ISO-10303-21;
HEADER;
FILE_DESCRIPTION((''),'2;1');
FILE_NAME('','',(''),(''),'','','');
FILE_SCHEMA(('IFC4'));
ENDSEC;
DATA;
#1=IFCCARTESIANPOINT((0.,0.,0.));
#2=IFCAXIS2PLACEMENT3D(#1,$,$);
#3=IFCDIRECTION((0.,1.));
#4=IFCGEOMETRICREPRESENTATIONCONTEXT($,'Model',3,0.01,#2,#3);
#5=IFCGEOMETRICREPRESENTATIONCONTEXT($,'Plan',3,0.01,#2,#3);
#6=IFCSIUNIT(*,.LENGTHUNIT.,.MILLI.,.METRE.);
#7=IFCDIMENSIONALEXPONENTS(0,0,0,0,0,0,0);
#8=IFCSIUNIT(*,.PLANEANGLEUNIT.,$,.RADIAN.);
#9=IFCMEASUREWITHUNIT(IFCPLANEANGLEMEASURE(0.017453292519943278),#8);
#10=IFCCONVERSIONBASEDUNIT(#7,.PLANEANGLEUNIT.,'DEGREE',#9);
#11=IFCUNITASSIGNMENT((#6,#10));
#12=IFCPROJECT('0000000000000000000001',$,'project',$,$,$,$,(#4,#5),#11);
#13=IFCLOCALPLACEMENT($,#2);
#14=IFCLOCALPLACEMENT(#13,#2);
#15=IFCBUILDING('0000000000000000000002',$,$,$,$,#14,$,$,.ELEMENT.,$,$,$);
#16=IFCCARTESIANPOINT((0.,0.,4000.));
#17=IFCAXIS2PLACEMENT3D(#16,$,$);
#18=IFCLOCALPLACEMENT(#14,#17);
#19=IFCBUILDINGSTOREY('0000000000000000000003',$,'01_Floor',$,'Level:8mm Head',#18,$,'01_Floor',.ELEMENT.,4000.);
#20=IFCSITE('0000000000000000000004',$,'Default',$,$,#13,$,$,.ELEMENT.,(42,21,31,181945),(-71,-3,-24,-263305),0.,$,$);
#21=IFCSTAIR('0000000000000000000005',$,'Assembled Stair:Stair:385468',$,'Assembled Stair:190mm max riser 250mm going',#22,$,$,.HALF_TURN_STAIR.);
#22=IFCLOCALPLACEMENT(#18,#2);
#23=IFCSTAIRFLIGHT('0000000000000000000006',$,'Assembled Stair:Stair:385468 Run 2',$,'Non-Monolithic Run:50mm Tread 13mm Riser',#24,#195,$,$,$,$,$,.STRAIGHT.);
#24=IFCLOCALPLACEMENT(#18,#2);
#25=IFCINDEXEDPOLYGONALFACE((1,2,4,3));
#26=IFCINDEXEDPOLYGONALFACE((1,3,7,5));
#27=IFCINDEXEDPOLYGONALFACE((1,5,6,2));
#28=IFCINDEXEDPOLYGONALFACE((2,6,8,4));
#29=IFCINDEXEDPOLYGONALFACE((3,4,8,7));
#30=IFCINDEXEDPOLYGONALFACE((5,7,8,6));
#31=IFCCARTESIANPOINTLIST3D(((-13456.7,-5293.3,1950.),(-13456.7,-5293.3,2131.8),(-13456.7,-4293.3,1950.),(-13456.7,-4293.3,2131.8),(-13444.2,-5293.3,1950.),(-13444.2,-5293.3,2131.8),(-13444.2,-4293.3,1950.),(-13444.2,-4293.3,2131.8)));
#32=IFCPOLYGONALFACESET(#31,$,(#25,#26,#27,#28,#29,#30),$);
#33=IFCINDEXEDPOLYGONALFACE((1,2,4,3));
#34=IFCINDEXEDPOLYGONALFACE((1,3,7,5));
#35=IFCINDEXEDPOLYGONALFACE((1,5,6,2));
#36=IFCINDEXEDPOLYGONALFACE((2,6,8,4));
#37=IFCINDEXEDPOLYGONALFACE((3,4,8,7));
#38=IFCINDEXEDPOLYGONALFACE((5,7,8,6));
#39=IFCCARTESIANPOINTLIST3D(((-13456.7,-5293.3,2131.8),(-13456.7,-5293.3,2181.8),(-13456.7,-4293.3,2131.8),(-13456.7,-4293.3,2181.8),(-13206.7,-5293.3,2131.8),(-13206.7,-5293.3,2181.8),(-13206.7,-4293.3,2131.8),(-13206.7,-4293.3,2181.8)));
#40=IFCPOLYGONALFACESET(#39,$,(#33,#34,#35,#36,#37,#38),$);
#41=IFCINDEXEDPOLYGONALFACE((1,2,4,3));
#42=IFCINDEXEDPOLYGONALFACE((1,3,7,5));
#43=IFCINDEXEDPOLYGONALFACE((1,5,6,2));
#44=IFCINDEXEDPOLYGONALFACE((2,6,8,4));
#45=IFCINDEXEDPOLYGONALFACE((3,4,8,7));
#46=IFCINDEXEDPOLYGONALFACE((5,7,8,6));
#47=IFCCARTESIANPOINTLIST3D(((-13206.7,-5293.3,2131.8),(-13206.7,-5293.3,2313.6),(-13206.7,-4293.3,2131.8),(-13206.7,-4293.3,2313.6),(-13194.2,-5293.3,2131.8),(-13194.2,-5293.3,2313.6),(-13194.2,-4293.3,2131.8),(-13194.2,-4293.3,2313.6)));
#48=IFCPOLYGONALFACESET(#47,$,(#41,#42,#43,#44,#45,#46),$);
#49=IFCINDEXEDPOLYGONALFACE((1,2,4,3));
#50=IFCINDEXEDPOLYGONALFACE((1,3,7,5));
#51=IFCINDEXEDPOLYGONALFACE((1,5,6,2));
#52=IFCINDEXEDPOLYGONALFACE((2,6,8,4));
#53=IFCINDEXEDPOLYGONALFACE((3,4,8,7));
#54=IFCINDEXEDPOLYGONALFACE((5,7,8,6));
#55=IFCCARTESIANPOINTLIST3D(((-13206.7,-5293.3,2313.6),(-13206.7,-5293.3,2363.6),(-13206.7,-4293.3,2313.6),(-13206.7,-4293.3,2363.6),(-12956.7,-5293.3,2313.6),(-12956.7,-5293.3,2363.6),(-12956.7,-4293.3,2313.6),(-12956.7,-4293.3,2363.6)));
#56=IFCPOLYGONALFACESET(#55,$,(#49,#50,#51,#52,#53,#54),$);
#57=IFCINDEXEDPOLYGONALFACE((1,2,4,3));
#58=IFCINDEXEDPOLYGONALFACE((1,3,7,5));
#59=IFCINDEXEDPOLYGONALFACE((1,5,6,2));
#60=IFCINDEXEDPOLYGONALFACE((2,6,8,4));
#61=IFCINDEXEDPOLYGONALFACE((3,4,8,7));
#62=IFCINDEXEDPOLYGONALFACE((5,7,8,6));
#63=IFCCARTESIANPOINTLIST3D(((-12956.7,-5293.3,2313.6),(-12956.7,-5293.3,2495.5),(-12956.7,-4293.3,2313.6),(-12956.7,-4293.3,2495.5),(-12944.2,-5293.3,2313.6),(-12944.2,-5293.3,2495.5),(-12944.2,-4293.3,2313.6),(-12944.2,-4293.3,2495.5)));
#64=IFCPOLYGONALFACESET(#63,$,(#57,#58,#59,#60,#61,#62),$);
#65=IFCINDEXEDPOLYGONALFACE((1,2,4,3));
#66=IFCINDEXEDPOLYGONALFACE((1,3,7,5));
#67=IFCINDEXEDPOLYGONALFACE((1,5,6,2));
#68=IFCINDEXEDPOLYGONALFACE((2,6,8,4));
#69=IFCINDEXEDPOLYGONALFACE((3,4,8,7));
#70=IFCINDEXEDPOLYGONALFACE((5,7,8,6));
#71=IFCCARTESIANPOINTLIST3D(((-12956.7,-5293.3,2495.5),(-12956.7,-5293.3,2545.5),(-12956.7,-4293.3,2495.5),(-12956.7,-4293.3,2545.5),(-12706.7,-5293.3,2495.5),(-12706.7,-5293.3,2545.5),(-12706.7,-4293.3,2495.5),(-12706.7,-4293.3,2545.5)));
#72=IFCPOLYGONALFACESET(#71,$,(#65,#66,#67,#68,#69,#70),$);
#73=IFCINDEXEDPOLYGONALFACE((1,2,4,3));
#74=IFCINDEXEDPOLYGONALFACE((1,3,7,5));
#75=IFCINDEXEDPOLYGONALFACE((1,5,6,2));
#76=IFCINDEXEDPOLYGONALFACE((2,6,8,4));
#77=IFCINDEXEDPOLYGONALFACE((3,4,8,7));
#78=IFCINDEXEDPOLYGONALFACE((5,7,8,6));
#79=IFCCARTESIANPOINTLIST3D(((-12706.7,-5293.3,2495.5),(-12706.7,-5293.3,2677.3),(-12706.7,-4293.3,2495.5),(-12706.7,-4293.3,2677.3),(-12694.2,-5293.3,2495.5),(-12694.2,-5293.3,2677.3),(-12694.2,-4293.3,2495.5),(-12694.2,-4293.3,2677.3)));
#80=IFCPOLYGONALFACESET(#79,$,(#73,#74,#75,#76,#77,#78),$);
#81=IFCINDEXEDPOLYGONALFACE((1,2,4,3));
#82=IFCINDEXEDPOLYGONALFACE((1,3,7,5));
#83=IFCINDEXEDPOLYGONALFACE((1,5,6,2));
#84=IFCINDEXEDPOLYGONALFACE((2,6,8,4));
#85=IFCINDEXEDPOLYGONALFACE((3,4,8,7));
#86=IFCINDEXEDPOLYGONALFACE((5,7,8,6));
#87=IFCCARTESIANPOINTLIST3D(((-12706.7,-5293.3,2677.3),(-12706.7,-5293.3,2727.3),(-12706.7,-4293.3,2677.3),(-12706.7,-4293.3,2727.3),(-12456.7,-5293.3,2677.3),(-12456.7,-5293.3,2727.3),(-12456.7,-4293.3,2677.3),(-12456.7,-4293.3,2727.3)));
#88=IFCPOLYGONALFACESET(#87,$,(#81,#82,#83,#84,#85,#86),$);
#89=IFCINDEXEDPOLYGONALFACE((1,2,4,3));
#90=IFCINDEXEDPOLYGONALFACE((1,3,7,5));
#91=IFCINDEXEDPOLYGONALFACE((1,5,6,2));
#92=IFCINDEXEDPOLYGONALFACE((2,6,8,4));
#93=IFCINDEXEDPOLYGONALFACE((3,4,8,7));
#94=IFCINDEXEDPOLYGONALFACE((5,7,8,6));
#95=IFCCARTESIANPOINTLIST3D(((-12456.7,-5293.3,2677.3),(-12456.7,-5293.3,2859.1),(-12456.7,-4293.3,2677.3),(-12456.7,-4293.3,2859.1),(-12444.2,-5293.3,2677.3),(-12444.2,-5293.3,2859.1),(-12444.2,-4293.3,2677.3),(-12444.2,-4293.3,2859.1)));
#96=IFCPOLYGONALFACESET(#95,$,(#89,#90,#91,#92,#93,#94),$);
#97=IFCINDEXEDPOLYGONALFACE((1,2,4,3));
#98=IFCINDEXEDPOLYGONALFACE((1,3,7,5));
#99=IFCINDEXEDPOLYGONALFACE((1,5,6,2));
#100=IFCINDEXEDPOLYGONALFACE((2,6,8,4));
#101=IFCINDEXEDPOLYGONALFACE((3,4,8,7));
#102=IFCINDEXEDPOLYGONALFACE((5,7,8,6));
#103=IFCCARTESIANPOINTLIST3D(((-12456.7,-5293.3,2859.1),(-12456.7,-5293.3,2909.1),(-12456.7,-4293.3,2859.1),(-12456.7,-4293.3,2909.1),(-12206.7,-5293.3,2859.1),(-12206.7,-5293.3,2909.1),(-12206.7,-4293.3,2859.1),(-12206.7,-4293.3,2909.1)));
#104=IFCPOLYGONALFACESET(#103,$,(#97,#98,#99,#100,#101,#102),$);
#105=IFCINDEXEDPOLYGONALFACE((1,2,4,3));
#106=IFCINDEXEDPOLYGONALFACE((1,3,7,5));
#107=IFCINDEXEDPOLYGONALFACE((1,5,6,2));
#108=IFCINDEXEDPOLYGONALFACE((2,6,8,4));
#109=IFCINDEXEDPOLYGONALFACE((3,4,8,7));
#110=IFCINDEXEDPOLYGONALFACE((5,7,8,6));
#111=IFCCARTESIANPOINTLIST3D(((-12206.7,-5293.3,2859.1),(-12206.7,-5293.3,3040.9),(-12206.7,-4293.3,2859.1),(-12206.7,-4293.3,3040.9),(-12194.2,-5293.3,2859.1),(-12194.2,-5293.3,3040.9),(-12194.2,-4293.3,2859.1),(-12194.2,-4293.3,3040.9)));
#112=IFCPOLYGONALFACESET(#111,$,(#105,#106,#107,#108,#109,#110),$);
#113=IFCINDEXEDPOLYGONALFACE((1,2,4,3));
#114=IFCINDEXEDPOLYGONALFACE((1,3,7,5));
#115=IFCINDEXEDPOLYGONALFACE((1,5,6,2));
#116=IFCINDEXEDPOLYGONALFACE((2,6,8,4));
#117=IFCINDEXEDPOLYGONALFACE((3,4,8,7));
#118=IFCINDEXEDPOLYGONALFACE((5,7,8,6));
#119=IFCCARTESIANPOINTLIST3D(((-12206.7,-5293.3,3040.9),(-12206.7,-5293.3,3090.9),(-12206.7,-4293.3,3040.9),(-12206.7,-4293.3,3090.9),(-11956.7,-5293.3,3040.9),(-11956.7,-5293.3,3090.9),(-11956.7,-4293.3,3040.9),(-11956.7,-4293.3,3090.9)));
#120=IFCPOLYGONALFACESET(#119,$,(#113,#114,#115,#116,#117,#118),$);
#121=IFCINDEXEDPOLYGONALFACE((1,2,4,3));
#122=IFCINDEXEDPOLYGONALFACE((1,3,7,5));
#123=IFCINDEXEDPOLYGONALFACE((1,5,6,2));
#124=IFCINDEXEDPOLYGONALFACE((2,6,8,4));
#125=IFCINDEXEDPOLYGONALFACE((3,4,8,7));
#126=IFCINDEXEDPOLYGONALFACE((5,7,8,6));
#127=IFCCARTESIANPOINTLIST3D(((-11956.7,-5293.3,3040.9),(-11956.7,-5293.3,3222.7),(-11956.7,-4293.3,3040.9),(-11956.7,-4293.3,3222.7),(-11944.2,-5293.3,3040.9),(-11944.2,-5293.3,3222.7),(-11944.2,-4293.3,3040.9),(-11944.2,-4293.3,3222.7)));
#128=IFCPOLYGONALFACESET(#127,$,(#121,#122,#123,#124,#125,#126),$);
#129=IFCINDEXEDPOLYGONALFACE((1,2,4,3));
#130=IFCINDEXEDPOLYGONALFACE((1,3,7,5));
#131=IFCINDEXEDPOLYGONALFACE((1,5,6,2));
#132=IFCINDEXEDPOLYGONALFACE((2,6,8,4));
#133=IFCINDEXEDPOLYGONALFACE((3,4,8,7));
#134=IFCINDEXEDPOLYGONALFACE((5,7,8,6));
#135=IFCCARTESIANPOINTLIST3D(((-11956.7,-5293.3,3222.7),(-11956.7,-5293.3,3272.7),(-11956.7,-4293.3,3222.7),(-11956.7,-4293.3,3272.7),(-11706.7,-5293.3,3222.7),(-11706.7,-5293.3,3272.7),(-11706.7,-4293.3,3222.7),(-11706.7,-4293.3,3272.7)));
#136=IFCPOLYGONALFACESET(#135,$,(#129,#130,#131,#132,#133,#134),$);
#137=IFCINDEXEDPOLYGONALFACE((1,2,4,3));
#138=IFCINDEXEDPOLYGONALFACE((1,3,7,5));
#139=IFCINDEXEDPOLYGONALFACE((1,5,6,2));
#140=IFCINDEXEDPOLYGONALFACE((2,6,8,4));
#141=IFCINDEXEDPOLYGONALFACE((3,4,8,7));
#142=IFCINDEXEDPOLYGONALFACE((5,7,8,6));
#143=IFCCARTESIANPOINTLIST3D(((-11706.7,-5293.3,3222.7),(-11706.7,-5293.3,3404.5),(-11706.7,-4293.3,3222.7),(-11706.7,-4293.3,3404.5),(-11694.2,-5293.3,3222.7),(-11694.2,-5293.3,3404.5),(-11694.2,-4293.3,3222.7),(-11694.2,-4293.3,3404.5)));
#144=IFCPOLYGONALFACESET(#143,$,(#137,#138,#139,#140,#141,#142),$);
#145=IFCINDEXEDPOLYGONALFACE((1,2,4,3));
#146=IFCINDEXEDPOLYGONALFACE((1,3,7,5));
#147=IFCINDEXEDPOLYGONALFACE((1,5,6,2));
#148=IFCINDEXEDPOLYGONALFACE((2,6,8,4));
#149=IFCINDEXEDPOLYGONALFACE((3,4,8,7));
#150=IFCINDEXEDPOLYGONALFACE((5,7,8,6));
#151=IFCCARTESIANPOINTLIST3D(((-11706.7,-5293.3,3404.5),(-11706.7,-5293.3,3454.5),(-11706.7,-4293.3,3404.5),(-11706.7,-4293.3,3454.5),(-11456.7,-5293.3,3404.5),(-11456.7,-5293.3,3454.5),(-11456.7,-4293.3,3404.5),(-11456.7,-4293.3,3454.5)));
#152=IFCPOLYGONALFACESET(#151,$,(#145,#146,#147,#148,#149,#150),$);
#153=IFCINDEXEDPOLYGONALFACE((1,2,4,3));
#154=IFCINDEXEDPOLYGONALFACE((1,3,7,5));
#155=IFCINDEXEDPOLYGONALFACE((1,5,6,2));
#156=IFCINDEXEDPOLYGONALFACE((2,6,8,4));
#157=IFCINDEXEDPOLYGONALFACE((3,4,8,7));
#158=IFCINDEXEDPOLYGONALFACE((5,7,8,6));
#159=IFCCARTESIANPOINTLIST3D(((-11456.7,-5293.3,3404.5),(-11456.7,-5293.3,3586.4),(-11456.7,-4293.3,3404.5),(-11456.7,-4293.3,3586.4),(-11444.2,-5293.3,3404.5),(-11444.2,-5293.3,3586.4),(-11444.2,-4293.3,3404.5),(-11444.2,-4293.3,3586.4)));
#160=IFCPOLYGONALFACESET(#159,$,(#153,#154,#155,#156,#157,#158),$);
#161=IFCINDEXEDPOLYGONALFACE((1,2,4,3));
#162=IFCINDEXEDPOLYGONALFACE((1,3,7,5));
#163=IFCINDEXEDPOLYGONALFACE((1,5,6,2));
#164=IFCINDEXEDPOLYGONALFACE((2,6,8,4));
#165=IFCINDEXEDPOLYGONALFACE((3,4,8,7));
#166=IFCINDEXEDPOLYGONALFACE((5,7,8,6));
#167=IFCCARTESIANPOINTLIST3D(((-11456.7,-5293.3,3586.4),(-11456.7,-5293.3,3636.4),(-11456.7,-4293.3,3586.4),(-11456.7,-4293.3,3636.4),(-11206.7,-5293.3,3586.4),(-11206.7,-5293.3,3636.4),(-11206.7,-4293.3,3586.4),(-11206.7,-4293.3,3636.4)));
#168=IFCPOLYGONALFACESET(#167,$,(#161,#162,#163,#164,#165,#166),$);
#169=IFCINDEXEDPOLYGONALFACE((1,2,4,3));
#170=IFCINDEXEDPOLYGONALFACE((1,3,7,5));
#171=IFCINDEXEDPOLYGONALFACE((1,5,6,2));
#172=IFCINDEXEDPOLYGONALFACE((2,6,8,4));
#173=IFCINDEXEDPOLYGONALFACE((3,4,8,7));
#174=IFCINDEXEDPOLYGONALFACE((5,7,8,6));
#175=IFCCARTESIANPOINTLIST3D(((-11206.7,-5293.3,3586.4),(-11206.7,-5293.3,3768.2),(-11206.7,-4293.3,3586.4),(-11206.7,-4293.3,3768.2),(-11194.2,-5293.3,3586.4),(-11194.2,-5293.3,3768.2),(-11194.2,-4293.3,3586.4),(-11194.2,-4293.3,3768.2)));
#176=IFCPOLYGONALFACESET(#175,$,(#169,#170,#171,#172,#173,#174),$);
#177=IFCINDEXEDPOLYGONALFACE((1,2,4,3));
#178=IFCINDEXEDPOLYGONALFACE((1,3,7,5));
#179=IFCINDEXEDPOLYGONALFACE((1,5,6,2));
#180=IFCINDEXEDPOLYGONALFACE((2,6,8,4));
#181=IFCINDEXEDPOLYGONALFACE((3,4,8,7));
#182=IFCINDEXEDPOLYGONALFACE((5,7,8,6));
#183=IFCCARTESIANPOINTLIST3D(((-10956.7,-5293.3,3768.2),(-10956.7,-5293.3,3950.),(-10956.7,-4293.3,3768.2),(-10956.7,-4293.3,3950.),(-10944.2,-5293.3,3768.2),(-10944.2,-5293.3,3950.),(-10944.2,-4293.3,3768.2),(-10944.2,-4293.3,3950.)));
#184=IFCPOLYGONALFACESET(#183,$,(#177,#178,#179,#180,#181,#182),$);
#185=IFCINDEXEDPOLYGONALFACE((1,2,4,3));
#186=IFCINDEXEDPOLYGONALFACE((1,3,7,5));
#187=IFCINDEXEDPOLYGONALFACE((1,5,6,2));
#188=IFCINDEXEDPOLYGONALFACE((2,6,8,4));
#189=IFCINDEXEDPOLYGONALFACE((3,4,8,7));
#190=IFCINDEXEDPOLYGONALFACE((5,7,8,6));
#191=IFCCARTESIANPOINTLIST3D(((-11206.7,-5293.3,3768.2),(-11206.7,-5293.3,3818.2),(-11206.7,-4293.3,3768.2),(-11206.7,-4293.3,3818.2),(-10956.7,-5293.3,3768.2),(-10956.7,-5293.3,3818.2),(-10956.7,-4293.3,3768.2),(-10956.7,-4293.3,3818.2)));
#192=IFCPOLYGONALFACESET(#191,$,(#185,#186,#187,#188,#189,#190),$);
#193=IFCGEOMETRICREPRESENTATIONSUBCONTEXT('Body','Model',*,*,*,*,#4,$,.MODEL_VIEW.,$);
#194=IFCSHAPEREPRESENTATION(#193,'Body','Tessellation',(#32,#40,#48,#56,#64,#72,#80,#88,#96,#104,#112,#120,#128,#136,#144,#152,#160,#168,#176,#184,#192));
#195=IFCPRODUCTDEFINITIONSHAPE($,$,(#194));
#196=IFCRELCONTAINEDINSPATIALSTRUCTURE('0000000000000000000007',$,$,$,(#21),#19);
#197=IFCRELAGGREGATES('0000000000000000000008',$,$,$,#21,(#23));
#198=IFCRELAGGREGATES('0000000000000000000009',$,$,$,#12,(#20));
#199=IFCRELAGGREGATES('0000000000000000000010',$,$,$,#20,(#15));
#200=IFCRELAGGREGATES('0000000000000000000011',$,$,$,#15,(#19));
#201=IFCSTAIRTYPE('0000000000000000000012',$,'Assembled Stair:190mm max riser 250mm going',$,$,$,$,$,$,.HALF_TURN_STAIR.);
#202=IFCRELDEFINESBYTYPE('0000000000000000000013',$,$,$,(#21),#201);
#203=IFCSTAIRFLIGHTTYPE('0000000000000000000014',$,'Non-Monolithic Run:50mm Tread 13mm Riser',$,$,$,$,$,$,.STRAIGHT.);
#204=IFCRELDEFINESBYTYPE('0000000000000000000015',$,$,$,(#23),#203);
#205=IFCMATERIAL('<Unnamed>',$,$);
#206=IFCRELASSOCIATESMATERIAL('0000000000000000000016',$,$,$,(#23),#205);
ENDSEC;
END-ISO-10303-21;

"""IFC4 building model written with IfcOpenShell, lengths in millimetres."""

from ifc_helpers import new_model, entity, si_unit, converted_unit, direction, frame, origin, place, context, subcontext, project, spatial, indexed_curve, outline, extrude, material, type_object, element, aggregate, save


model = new_model("IFC4")

# Units and contexts
model_context = context("Model", 3, precision=0.01, world=origin(), true_north=direction((0.0, 1.0)))
plan_context = context("Plan", 3, precision=0.01, world=origin(), true_north=direction((0.0, 1.0)))
body_context = subcontext(model_context, "Body", "Model", "MODEL_VIEW")
ifc_project = project(units=[si_unit("LENGTHUNIT", "METRE", prefix="MILLI"), converted_unit("PLANEANGLEUNIT", "DEGREE", entity("IfcPlaneAngleMeasure", 0.017453292519943278), si_unit("PLANEANGLEUNIT", "RADIAN"), dimensions=[0, 0, 0, 0, 0, 0, 0])], contexts=[model_context, plan_context])

# Site, building, storey
site_placement = place(None, origin())
site = spatial("IfcSite", under=ifc_project, at=site_placement, Name="Default", CompositionType="ELEMENT", RefLatitude=(42, 21, 31, 181945), RefLongitude=(-71, -3, -24, -263305), RefElevation=0.0)
building_placement = place(site_placement, origin())
building = spatial("IfcBuilding", under=site, at=building_placement, CompositionType="ELEMENT")
storey_placement = place(building_placement, frame((0.0, 0.0, 4000.0)))
storey = spatial("IfcBuildingStorey", under=building, at=storey_placement, Name="01_Floor", ObjectType="Level:8mm Head", LongName="01_Floor", CompositionType="ELEMENT", Elevation=4000.0)

# Stair
stair_type = type_object("IfcStairType", Name="Assembled Stair:190mm max riser 250mm going", PredefinedType="HALF_TURN_STAIR")
stair_placement = place(storey_placement, origin())
stair = element("IfcStair", 1, at=stair_placement, inside=storey, type_object=stair_type, Name="Assembled Stair:Stair:385468", ObjectType="Assembled Stair:190mm max riser 250mm going", PredefinedType="HALF_TURN_STAIR")
ifc_material_1 = material(Name="<Unnamed>")

# Stair flight
stair_flight_type = type_object("IfcStairFlightType", Name="Non-Monolithic Run:50mm Tread 13mm Riser", PredefinedType="STRAIGHT")
stair_flight_1_placement = place(stair_placement, origin())
stair_flight_1 = element("IfcStairFlight", 2, at=stair_flight_1_placement, type_object=stair_flight_type, material=ifc_material_1, Name="Assembled Stair:Stair:385468 Run 2", ObjectType="Non-Monolithic Run:50mm Tread 13mm Riser", PredefinedType="STRAIGHT", context=body_context, shape_type="SweptSolid", body=[
    extrude(outline(indexed_curve([(-500.0, -6.3), (500.0, -6.3), (500.0, 6.2), (-500.0, 6.2), (-500.0, -6.3)], self_intersect=False)), frame((-13450.4, -4793.3, 1950.0), z_axis=(0.0, 0.0, 1.0), x_axis=(0.0, 1.0, 0.0)), (0.0, 0.0, 1.0), 181.8),
    extrude(outline(indexed_curve([(-125.0, -500.0), (125.0, -500.0), (125.0, 500.0), (-125.0, 500.0), (-125.0, -500.0)], self_intersect=False)), frame((-13331.7, -4793.3, 2131.8), z_axis=(0.0, 0.0, 1.0), x_axis=(-1.0, 0.0, 0.0)), (0.0, 0.0, 1.0), 50.0),
    extrude(outline(indexed_curve([(-500.0, -6.2), (500.0, -6.2), (500.0, 6.2), (-500.0, 6.2), (-500.0, -6.2)], self_intersect=False)), frame((-13200.4, -4793.3, 2131.8), z_axis=(0.0, 0.0, 1.0), x_axis=(0.0, 1.0, 0.0)), (0.0, 0.0, 1.0), 181.8),
    extrude(outline(indexed_curve([(-125.0, -500.0), (125.0, -500.0), (125.0, 500.0), (-125.0, 500.0), (-125.0, -500.0)], self_intersect=False)), frame((-13081.7, -4793.3, 2313.6), z_axis=(0.0, 0.0, 1.0), x_axis=(-1.0, 0.0, 0.0)), (0.0, 0.0, 1.0), 50.0),
    extrude(outline(indexed_curve([(-500.0, -6.2), (500.0, -6.2), (500.0, 6.3), (-500.0, 6.3), (-500.0, -6.2)], self_intersect=False)), frame((-12950.4, -4793.3, 2313.6), z_axis=(0.0, 0.0, 1.0), x_axis=(0.0, 1.0, 0.0)), (0.0, 0.0, 1.0), 181.8),
    extrude(outline(indexed_curve([(-125.0, -500.0), (125.0, -500.0), (125.0, 500.0), (-125.0, 500.0), (-125.0, -500.0)], self_intersect=False)), frame((-12831.7, -4793.3, 2495.5), z_axis=(0.0, 0.0, 1.0), x_axis=(-1.0, 0.0, 0.0)), (0.0, 0.0, 1.0), 50.0),
    extrude(outline(indexed_curve([(-500.0, -6.2), (500.0, -6.2), (500.0, 6.2), (-500.0, 6.2), (-500.0, -6.2)], self_intersect=False)), frame((-12700.4, -4793.3, 2495.5), z_axis=(0.0, 0.0, 1.0), x_axis=(0.0, 1.0, 0.0)), (0.0, 0.0, 1.0), 181.8),
    extrude(outline(indexed_curve([(-125.0, -500.0), (125.0, -500.0), (125.0, 500.0), (-125.0, 500.0), (-125.0, -500.0)], self_intersect=False)), frame((-12581.7, -4793.3, 2677.3), z_axis=(0.0, 0.0, 1.0), x_axis=(-1.0, 0.0, 0.0)), (0.0, 0.0, 1.0), 50.0),
    extrude(outline(indexed_curve([(-500.0, -6.2), (500.0, -6.2), (500.0, 6.3), (-500.0, 6.3), (-500.0, -6.2)], self_intersect=False)), frame((-12450.4, -4793.3, 2677.3), z_axis=(0.0, 0.0, 1.0), x_axis=(0.0, 1.0, 0.0)), (0.0, 0.0, 1.0), 181.8),
    extrude(outline(indexed_curve([(-125.0, -500.0), (125.0, -500.0), (125.0, 500.0), (-125.0, 500.0), (-125.0, -500.0)], self_intersect=False)), frame((-12331.7, -4793.3, 2859.1), z_axis=(0.0, 0.0, 1.0), x_axis=(-1.0, 0.0, 0.0)), (0.0, 0.0, 1.0), 50.0),
    extrude(outline(indexed_curve([(-500.0, -6.2), (500.0, -6.2), (500.0, 6.2), (-500.0, 6.2), (-500.0, -6.2)], self_intersect=False)), frame((-12200.4, -4793.3, 2859.1), z_axis=(0.0, 0.0, 1.0), x_axis=(0.0, 1.0, 0.0)), (0.0, 0.0, 1.0), 181.8),
    extrude(outline(indexed_curve([(-125.0, -500.0), (125.0, -500.0), (125.0, 500.0), (-125.0, 500.0), (-125.0, -500.0)], self_intersect=False)), frame((-12081.7, -4793.3, 3040.9), z_axis=(0.0, 0.0, 1.0), x_axis=(-1.0, 0.0, 0.0)), (0.0, 0.0, 1.0), 50.0),
    extrude(outline(indexed_curve([(-500.0, -6.2), (500.0, -6.2), (500.0, 6.3), (-500.0, 6.3), (-500.0, -6.2)], self_intersect=False)), frame((-11950.4, -4793.3, 3040.9), z_axis=(0.0, 0.0, 1.0), x_axis=(0.0, 1.0, 0.0)), (0.0, 0.0, 1.0), 181.8),
    extrude(outline(indexed_curve([(-125.0, -500.0), (125.0, -500.0), (125.0, 500.0), (-125.0, 500.0), (-125.0, -500.0)], self_intersect=False)), frame((-11831.7, -4793.3, 3222.7), z_axis=(0.0, 0.0, 1.0), x_axis=(-1.0, 0.0, 0.0)), (0.0, 0.0, 1.0), 50.0),
    extrude(outline(indexed_curve([(-500.0, -6.2), (500.0, -6.2), (500.0, 6.2), (-500.0, 6.2), (-500.0, -6.2)], self_intersect=False)), frame((-11700.4, -4793.3, 3222.7), z_axis=(0.0, 0.0, 1.0), x_axis=(0.0, 1.0, 0.0)), (0.0, 0.0, 1.0), 181.8),
    extrude(outline(indexed_curve([(-125.0, -500.0), (125.0, -500.0), (125.0, 500.0), (-125.0, 500.0), (-125.0, -500.0)], self_intersect=False)), frame((-11581.7, -4793.3, 3404.5), z_axis=(0.0, 0.0, 1.0), x_axis=(-1.0, 0.0, 0.0)), (0.0, 0.0, 1.0), 50.0),
    extrude(outline(indexed_curve([(-500.0, -6.2), (500.0, -6.2), (500.0, 6.3), (-500.0, 6.3), (-500.0, -6.2)], self_intersect=False)), frame((-11450.4, -4793.3, 3404.5), z_axis=(0.0, 0.0, 1.0), x_axis=(0.0, 1.0, 0.0)), (0.0, 0.0, 1.0), 181.8),
    extrude(outline(indexed_curve([(-125.0, -500.0), (125.0, -500.0), (125.0, 500.0), (-125.0, 500.0), (-125.0, -500.0)], self_intersect=False)), frame((-11331.7, -4793.3, 3586.4), z_axis=(0.0, 0.0, 1.0), x_axis=(-1.0, 0.0, 0.0)), (0.0, 0.0, 1.0), 50.0),
    extrude(outline(indexed_curve([(-500.0, -6.2), (500.0, -6.2), (500.0, 6.2), (-500.0, 6.2), (-500.0, -6.2)], self_intersect=False)), frame((-11200.4, -4793.3, 3586.4), z_axis=(0.0, 0.0, 1.0), x_axis=(0.0, 1.0, 0.0)), (0.0, 0.0, 1.0), 181.8),
    extrude(outline(indexed_curve([(-500.0, -6.2), (500.0, -6.2), (500.0, 6.3), (-500.0, 6.3), (-500.0, -6.2)], self_intersect=False)), frame((-10950.4, -4793.3, 3768.2), z_axis=(0.0, 0.0, 1.0), x_axis=(0.0, 1.0, 0.0)), (0.0, 0.0, 1.0), 181.8),
    extrude(outline(indexed_curve([(-125.0, -500.0), (125.0, -500.0), (125.0, 500.0), (-125.0, 500.0), (-125.0, -500.0)], self_intersect=False)), frame((-11081.7, -4793.3, 3768.2), z_axis=(0.0, 0.0, 1.0), x_axis=(-1.0, 0.0, 0.0)), (0.0, 0.0, 1.0), 50.0),
])
aggregate(stair, [stair_flight_1])

save(model, "model.ifc")
